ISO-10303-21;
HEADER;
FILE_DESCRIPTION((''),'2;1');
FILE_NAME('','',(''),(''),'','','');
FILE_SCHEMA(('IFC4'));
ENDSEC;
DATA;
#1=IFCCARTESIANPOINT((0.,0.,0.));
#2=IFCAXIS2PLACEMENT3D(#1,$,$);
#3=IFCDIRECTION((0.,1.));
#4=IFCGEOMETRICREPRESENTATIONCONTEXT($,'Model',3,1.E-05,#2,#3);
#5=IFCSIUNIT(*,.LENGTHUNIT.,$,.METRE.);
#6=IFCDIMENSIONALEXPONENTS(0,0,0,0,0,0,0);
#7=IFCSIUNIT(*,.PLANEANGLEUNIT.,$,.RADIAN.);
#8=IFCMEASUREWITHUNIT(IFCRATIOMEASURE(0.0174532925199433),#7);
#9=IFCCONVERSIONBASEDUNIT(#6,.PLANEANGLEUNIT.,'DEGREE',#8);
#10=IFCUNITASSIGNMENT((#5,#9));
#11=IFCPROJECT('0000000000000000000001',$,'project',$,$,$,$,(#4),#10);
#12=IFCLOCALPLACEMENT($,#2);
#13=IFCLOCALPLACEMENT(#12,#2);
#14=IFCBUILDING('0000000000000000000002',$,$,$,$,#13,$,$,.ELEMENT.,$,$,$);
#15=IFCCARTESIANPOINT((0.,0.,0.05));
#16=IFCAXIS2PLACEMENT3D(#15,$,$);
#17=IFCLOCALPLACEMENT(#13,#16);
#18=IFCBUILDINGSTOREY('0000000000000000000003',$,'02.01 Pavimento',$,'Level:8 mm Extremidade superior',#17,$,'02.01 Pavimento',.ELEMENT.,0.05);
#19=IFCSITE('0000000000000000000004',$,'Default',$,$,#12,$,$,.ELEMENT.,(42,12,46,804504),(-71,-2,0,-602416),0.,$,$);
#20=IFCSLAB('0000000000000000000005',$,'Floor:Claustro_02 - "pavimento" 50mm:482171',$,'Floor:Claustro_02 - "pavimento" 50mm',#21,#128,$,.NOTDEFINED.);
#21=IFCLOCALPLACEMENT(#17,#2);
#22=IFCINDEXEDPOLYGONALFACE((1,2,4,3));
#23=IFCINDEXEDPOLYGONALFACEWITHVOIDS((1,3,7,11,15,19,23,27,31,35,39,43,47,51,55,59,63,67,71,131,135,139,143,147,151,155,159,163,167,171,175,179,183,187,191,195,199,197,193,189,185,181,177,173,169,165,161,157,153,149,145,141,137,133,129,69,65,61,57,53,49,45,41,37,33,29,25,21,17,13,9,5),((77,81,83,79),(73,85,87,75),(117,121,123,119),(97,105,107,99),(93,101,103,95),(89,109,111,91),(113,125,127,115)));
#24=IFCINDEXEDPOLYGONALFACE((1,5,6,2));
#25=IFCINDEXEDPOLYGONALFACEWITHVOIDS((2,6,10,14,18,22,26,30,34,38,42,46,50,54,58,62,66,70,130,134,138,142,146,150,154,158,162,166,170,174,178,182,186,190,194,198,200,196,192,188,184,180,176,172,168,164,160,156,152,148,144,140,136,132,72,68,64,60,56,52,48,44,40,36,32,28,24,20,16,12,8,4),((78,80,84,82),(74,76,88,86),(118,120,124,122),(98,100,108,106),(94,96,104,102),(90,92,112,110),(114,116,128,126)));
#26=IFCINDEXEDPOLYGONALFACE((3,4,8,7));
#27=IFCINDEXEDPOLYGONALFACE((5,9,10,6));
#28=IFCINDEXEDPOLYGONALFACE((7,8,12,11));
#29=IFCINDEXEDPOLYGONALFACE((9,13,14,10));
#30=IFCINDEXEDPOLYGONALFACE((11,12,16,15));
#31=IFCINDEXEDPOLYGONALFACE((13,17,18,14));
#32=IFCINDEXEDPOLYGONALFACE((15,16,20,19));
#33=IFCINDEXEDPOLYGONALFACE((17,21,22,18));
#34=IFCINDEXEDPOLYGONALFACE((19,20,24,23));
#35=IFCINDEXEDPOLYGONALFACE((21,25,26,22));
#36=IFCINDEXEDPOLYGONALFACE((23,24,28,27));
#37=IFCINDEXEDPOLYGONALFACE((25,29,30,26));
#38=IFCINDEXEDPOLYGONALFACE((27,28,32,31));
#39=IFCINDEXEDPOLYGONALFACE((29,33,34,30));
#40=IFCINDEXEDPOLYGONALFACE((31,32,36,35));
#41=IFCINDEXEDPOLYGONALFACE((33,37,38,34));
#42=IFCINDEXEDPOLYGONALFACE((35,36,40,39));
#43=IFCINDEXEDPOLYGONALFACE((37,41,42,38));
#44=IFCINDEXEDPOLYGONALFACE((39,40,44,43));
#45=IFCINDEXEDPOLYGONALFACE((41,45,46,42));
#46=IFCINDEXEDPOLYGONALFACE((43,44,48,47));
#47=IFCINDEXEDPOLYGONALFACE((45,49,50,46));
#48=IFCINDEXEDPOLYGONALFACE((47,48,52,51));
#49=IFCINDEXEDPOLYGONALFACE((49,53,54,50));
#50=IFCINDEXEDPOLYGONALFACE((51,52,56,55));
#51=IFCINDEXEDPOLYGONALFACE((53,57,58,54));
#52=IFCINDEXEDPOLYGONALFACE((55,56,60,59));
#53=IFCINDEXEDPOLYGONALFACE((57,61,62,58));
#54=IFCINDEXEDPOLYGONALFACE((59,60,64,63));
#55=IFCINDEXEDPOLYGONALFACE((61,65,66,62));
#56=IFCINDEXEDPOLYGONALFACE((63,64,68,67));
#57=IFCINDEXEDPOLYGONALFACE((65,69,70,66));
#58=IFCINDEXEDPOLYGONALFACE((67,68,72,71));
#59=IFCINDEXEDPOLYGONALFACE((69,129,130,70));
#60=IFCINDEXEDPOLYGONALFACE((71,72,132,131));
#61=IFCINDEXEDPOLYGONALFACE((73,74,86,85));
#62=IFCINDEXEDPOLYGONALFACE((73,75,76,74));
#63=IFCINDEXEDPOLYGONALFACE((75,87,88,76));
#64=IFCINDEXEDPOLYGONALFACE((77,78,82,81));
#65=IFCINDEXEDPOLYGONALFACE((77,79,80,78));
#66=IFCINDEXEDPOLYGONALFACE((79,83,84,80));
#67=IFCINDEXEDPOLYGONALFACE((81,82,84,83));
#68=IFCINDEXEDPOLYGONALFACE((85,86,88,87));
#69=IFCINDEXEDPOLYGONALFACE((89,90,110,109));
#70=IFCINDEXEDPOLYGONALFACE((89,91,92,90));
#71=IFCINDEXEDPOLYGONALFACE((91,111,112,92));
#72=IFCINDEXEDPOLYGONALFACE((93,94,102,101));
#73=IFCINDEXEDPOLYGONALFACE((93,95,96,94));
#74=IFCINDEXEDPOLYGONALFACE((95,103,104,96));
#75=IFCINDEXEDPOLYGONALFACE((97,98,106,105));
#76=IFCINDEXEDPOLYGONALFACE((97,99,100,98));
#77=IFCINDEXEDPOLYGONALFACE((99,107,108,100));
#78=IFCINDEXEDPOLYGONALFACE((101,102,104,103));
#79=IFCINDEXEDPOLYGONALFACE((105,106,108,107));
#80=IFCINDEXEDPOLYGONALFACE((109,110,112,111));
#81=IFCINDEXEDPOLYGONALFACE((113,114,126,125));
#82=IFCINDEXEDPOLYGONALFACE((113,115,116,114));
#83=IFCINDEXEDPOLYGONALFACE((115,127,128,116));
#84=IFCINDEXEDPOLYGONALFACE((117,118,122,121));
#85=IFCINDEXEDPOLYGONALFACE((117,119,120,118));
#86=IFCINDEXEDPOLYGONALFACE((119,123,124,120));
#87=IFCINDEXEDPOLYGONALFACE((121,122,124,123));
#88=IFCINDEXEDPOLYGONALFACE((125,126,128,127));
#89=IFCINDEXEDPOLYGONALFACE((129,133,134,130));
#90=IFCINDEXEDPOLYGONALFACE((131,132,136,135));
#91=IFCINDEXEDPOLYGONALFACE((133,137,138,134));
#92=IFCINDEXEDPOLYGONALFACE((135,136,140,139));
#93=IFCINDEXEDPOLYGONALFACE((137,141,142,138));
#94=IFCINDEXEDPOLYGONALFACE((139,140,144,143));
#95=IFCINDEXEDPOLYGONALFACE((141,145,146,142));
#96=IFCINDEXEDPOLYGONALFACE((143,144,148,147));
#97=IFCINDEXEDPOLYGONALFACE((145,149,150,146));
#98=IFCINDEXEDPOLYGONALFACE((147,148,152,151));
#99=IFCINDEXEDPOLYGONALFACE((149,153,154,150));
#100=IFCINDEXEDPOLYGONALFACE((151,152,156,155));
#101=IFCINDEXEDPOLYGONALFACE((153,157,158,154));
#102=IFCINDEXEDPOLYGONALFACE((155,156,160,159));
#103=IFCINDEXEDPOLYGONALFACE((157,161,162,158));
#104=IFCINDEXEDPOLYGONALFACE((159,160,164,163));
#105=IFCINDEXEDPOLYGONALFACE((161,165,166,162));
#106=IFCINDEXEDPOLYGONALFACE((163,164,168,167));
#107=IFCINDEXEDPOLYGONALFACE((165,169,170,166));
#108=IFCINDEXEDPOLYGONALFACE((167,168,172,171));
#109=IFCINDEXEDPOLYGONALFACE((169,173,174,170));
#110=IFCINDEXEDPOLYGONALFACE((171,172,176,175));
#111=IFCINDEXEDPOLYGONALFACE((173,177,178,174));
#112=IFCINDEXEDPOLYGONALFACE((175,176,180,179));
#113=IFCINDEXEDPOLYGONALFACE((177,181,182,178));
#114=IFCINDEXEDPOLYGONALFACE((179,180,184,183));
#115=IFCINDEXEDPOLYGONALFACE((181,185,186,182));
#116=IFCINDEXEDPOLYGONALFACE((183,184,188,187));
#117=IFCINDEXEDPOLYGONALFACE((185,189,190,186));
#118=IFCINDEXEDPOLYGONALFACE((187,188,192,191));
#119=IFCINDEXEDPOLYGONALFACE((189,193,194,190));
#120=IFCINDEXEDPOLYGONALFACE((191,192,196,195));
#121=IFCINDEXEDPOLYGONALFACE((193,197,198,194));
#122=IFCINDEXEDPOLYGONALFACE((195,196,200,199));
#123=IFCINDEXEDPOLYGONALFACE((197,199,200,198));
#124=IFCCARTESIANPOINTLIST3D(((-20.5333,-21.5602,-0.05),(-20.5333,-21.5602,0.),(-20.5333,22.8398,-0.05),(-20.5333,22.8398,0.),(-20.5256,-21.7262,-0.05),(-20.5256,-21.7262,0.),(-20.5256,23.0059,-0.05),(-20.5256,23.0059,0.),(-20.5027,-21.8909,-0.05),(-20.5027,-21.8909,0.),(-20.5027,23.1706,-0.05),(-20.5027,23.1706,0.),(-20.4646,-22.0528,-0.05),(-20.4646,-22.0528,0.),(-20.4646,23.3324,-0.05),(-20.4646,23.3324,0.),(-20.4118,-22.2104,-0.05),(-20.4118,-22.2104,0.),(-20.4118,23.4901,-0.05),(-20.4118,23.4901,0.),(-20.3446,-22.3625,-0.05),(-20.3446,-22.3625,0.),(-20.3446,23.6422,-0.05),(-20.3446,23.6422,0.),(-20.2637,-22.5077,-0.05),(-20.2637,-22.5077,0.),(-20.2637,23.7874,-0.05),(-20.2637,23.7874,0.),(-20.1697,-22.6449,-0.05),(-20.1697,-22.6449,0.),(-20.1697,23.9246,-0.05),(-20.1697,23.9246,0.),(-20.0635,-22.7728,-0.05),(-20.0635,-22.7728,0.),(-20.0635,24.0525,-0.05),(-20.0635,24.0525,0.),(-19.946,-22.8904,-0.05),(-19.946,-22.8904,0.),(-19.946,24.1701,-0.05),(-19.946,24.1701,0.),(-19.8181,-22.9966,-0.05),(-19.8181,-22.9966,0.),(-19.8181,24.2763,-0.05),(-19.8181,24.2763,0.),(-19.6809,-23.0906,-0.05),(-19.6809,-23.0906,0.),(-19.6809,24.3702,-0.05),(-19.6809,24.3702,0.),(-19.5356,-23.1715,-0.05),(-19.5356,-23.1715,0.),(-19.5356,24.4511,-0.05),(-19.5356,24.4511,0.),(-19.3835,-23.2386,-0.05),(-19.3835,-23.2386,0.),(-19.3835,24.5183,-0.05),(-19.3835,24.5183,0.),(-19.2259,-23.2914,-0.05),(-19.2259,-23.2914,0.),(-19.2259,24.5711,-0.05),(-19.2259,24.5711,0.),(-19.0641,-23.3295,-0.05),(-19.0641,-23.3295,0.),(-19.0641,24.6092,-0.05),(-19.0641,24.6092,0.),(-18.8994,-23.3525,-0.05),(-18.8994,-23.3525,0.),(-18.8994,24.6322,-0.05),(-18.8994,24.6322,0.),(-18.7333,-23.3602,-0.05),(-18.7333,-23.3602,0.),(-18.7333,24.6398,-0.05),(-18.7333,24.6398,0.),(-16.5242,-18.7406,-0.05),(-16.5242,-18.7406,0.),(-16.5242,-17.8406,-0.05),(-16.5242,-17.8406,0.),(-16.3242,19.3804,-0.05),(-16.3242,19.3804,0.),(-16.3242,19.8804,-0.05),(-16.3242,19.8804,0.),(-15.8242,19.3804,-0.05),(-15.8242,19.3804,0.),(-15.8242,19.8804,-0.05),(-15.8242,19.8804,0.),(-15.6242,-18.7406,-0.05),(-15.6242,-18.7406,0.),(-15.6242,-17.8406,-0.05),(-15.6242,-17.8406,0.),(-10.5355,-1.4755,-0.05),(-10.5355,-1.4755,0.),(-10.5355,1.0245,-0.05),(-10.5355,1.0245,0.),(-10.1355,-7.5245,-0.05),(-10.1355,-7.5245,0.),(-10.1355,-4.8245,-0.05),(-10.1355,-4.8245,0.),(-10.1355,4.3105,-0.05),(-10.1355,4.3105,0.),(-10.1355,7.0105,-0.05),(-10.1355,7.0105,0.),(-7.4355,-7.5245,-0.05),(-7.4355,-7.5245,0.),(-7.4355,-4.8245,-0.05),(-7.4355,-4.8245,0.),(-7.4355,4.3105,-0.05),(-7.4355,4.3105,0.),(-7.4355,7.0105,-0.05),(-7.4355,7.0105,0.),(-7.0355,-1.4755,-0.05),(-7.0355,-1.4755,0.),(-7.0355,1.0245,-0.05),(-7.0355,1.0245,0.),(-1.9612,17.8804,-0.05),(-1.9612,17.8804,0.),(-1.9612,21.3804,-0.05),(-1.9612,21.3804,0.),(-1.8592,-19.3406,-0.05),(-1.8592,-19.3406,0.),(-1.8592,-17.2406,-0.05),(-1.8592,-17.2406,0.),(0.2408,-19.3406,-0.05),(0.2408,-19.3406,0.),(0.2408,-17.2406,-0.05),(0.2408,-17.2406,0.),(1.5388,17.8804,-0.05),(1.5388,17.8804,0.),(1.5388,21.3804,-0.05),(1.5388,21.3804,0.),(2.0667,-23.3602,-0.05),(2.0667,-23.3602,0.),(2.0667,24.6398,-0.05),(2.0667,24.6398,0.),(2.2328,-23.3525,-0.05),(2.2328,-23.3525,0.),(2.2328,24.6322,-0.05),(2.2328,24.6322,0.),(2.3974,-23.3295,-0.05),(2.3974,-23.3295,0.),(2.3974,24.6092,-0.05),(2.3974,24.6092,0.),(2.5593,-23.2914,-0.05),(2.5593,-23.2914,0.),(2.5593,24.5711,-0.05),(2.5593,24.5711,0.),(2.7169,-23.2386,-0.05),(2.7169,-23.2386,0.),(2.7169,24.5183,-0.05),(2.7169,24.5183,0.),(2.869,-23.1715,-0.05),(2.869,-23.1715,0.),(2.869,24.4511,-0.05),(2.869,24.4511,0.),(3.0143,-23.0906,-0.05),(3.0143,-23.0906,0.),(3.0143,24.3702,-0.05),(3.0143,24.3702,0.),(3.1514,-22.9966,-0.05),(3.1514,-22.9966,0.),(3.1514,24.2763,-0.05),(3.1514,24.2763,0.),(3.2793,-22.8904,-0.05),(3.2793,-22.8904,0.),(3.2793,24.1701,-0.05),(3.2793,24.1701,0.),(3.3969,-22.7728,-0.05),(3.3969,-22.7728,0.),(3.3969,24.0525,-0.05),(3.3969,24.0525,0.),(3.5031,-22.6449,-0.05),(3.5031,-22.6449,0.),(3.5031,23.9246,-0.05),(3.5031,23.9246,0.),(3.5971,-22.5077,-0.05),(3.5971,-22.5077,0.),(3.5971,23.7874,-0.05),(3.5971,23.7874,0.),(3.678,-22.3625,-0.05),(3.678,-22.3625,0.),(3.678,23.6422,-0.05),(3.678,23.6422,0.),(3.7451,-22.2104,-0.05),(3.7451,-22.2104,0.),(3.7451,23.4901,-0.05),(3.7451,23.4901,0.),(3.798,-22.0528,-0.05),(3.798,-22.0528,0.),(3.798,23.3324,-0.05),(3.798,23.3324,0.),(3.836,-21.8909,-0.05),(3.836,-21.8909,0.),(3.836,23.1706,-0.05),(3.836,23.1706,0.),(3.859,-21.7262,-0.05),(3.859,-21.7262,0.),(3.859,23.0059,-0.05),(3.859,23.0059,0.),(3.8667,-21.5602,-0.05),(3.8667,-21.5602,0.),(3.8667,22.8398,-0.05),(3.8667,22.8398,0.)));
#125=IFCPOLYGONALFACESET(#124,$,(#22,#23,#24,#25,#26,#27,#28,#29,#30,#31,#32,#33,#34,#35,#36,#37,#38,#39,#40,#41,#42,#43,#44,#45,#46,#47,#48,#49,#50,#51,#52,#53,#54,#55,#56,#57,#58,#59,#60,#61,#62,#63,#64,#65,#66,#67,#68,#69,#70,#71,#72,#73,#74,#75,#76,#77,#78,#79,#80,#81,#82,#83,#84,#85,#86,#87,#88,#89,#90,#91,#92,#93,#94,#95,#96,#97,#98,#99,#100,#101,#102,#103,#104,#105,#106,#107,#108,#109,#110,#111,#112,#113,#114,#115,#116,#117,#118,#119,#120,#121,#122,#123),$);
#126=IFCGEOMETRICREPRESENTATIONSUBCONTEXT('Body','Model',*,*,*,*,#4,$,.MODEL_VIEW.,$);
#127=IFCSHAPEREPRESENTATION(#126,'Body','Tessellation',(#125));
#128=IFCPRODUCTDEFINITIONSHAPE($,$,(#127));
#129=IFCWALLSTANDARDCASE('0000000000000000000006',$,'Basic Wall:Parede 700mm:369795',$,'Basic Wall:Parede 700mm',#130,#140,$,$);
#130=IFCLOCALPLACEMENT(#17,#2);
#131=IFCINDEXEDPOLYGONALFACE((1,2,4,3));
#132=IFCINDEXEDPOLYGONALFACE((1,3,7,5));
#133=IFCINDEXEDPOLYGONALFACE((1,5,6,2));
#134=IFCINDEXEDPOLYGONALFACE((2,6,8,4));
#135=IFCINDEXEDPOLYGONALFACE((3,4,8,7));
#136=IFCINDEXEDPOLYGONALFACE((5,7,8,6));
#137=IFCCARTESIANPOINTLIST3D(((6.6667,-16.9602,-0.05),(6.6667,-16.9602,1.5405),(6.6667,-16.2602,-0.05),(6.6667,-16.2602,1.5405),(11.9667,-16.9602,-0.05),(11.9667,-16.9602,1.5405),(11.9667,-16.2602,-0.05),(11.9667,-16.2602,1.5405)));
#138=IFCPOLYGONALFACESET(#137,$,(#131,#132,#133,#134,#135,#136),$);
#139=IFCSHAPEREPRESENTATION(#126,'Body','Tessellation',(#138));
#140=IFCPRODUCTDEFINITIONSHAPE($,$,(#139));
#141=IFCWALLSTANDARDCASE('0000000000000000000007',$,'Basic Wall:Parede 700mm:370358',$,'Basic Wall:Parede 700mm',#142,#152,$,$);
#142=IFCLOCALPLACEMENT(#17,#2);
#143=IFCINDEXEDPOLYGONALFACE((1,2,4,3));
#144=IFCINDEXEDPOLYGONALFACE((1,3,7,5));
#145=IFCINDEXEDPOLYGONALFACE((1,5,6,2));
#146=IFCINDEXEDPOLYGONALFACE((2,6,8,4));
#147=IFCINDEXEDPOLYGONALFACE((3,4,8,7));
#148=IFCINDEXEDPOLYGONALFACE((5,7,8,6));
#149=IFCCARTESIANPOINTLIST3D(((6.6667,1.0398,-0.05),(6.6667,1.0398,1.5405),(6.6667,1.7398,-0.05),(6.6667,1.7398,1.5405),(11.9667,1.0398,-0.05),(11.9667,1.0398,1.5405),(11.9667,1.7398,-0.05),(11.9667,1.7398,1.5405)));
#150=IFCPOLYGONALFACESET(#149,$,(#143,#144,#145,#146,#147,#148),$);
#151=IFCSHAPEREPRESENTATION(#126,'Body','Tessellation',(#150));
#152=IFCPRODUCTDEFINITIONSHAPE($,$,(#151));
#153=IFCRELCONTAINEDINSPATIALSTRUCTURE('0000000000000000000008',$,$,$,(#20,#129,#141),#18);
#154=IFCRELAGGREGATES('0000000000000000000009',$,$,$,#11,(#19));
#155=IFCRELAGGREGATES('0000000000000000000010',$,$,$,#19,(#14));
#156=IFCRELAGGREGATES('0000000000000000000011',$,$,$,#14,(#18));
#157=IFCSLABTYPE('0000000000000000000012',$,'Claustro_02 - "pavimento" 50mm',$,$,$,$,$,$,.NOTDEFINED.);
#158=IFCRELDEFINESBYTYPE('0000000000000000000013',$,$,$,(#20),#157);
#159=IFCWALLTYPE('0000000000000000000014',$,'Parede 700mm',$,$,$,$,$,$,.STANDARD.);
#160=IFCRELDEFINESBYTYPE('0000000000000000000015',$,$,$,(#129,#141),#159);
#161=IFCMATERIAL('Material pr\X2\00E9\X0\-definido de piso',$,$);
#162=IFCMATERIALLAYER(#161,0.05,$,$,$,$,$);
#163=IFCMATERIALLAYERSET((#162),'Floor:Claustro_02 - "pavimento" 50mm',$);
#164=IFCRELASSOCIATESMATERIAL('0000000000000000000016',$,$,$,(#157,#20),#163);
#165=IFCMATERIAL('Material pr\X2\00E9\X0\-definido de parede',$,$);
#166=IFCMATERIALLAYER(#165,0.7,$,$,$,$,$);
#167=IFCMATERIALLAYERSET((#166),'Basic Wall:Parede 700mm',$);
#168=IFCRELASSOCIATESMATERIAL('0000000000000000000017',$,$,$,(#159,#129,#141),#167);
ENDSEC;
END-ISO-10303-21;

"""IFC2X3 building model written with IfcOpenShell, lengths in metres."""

from ifc_helpers import new_model, entity, si_unit, converted_unit, direction, frame, frame_2d, origin, origin_2d_with_axis, place, context, subcontext, project, spatial, polyline, circle_curve, parameter, trimmed, segment, composite_curve, rectangle, outline, extrude, clip, halfspace, material, layer, layer_set, layer_usage, type_object, element, save


model = new_model("IFC2X3")

# Units and contexts
model_context = context("Model", 3, precision=1e-05, world=origin(), true_north=direction((0.0, 1.0)))
body_context = subcontext(model_context, "Body", "Model", "MODEL_VIEW")
ifc_project = project(units=[si_unit("LENGTHUNIT", "METRE"), converted_unit("PLANEANGLEUNIT", "DEGREE", entity("IfcRatioMeasure", 0.0174532925199433), si_unit("PLANEANGLEUNIT", "RADIAN"), dimensions=[0, 0, 0, 0, 0, 0, 0])], contexts=[model_context])

# Site, building, storey
site_placement = place(None, origin())
site = spatial("IfcSite", under=ifc_project, at=site_placement, Name="Default", CompositionType="ELEMENT", RefLatitude=(42, 12, 46, 804504), RefLongitude=(-71, -2, 0, -602416), RefElevation=0.0)
building_placement = place(site_placement, origin())
building = spatial("IfcBuilding", under=site, at=building_placement, CompositionType="ELEMENT")
storey_placement = place(building_placement, frame((0.0, 0.0, 0.05)))
storey = spatial("IfcBuildingStorey", under=building, at=storey_placement, Name="02.01 Pavimento", ObjectType="Level:8 mm Extremidade superior", LongName="02.01 Pavimento", CompositionType="ELEMENT", Elevation=0.05)

# Shared definitions
ifc_material_1 = material(Name="Material pré-definido de piso")

# Slab, openings
ifc_layer_1 = layer(ifc_material_1, 0.05)
ifc_layer_set_1 = layer_set([ifc_layer_1], Name="Floor:Claustro_02 - \"pavimento\" 50mm")
ifc_layer_usage_1 = layer_usage(ifc_layer_set_1, "AXIS3", "POSITIVE", 0.0)
slab_type_1 = type_object("IfcSlabType", Name="Claustro_02 - \"pavimento\" 50mm", PredefinedType="NOTDEFINED", material=ifc_layer_set_1)
slab_1_placement = place(storey_placement, origin())
slab_1 = element("IfcSlab", 1, at=slab_1_placement, inside=storey, type_object=slab_type_1, material=ifc_layer_usage_1, Name="Floor:Claustro_02 - \"pavimento\" 50mm:482171", ObjectType="Floor:Claustro_02 - \"pavimento\" 50mm", PredefinedType="NOTDEFINED", context=body_context, shape_type="SweptSolid", body=[
    extrude(outline(composite_curve([segment(trimmed(circle_curve(frame_2d((-10.4, 22.2), x_axis=(-1.0, 0.0)), 1.8), [parameter(270.0)], [parameter(0.0)], True, "PARAMETER"), True, "CONTINUOUS"), segment(polyline([(-12.2, 22.2), (-12.2, 3.95)]), True, "CONTINUOUS"), segment(polyline([(-12.2, 3.95), (-12.2, -22.2)]), True, "CONTINUOUS"), segment(trimmed(circle_curve(frame_2d((-10.4, -22.2), x_axis=(-1.0, 0.0)), 1.8), [parameter(0.0)], [parameter(90.0)], True, "PARAMETER"), True, "CONTINUOUS"), segment(polyline([(-10.4, -24.0), (10.4, -24.0)]), True, "CONTINUOUS"), segment(trimmed(circle_curve(frame_2d((10.4, -22.2), x_axis=(-1.0, 0.0)), 1.8), [parameter(90.0)], [parameter(180.0)], True, "PARAMETER"), True, "CONTINUOUS"), segment(polyline([(12.2, -22.2), (12.2, 3.95)]), True, "CONTINUOUS"), segment(polyline([(12.2, 3.95), (12.2, 22.2)]), True, "CONTINUOUS"), segment(trimmed(circle_curve(frame_2d((10.4, 22.2), x_axis=(-1.0, 0.0)), 1.8), [parameter(180.0)], [parameter(270.0)], True, "PARAMETER"), True, "CONTINUOUS"), segment(polyline([(10.4, 24.0), (-10.4, 24.0)]), True, "CONTINUOUS")], self_intersect=False)), frame((-8.3333, 0.6398, 0.0), z_axis=(0.0, 0.0, -1.0), x_axis=(-1.0, 0.0, 0.0)), (0.0, 0.0, 1.0), 0.05),
])
opening_1_placement = place(slab_1_placement, frame((-0.2112, 19.6304, 0.0)))
element("IfcOpeningElement", 2, at=opening_1_placement, cuts=slab_1, ObjectType="Opening", context=body_context, shape_type="SweptSolid", body=[
    extrude(rectangle(XDim=3.5, YDim=3.5, at=origin_2d_with_axis()), frame((0.0, 0.0, 0.0), z_axis=(0.0, 0.0, -1.0), x_axis=(0.0, -1.0, 0.0)), (0.0, 0.0, 1.0), 0.05),
])
opening_2_placement = place(slab_1_placement, frame((-16.0742, 19.6304, 0.0)))
element("IfcOpeningElement", 3, at=opening_2_placement, cuts=slab_1, ObjectType="Opening", context=body_context, shape_type="SweptSolid", body=[
    extrude(rectangle(XDim=0.5, YDim=0.5, at=origin_2d_with_axis()), frame((0.0, 0.0, 0.0), z_axis=(0.0, 0.0, -1.0), x_axis=(0.0, -1.0, 0.0)), (0.0, 0.0, 1.0), 0.05),
])
opening_3_placement = place(slab_1_placement, frame((-8.7855, 5.6605, 0.0)))
element("IfcOpeningElement", 4, at=opening_3_placement, cuts=slab_1, ObjectType="Opening", context=body_context, shape_type="SweptSolid", body=[
    extrude(rectangle(XDim=2.7, YDim=2.7, at=origin_2d_with_axis()), frame((0.0, 0.0, 0.0), z_axis=(0.0, 0.0, -1.0), x_axis=(0.0, -1.0, 0.0)), (0.0, 0.0, 1.0), 0.05),
])
opening_4_placement = place(slab_1_placement, frame((-8.7855, -0.2255, 0.0)))
element("IfcOpeningElement", 5, at=opening_4_placement, cuts=slab_1, ObjectType="Opening", context=body_context, shape_type="SweptSolid", body=[
    extrude(rectangle(XDim=2.5, YDim=3.5, at=origin_2d_with_axis()), frame((0.0, 0.0, 0.0), z_axis=(0.0, 0.0, -1.0), x_axis=(0.0, -1.0, 0.0)), (0.0, 0.0, 1.0), 0.05),
])
opening_5_placement = place(slab_1_placement, frame((-8.7855, -6.1745, 0.0)))
element("IfcOpeningElement", 6, at=opening_5_placement, cuts=slab_1, ObjectType="Opening", context=body_context, shape_type="SweptSolid", body=[
    extrude(rectangle(XDim=2.7, YDim=2.7, at=origin_2d_with_axis()), frame((0.0, 0.0, 0.0), z_axis=(0.0, 0.0, -1.0), x_axis=(0.0, -1.0, 0.0)), (0.0, 0.0, 1.0), 0.05),
])
opening_6_placement = place(slab_1_placement, frame((-16.0742, -18.2906, 0.0)))
element("IfcOpeningElement", 7, at=opening_6_placement, cuts=slab_1, ObjectType="Opening", context=body_context, shape_type="SweptSolid", body=[
    extrude(rectangle(XDim=0.9, YDim=0.9, at=origin_2d_with_axis()), frame((0.0, 0.0, 0.0), z_axis=(0.0, 0.0, -1.0), x_axis=(0.0, -1.0, 0.0)), (0.0, 0.0, 1.0), 0.05),
])
opening_7_placement = place(slab_1_placement, frame((-0.8092, -18.2906, 0.0)))
element("IfcOpeningElement", 8, at=opening_7_placement, cuts=slab_1, ObjectType="Opening", context=body_context, shape_type="SweptSolid", body=[
    extrude(rectangle(XDim=2.1, YDim=2.1, at=origin_2d_with_axis()), frame((0.0, 0.0, 0.0), z_axis=(0.0, 0.0, -1.0), x_axis=(0.0, -1.0, 0.0)), (0.0, 0.0, 1.0), 0.05),
])

# Walls
ifc_material_2 = material(Name="Material pré-definido de parede")
ifc_layer_2 = layer(ifc_material_2, 0.7)
ifc_layer_set_2 = layer_set([ifc_layer_2], Name="Basic Wall:Parede 700mm")
ifc_layer_usage_2 = layer_usage(ifc_layer_set_2, "AXIS2", "NEGATIVE", 0.35)
wall_type_1 = type_object("IfcWallType", Name="Parede 700mm", PredefinedType="STANDARD", material=ifc_layer_set_2)
wall_1_placement = place(storey_placement, frame((6.6667, -16.6102, -0.05)))
element("IfcWallStandardCase", 9, at=wall_1_placement, inside=storey, type_object=wall_type_1, material=ifc_layer_usage_2, Name="Basic Wall:Parede 700mm:369795", ObjectType="Basic Wall:Parede 700mm", context=body_context, shape_type="Clipping", body=[
    clip(extrude(rectangle(XDim=0.7, YDim=5.3, at=frame_2d((2.65, 0.0), x_axis=(0.0, 1.0))), origin(), (0.0, 0.0, 1.0), 1.5905), halfspace(frame((0.0, 0.0, -0.05)), True)),
])
ifc_layer_usage_3 = layer_usage(ifc_layer_set_2, "AXIS2", "POSITIVE", -0.35)
wall_2_placement = place(storey_placement, frame((6.6667, 1.3898, -0.05)))
element("IfcWallStandardCase", 10, at=wall_2_placement, inside=storey, type_object=wall_type_1, material=ifc_layer_usage_3, Name="Basic Wall:Parede 700mm:370358", ObjectType="Basic Wall:Parede 700mm", context=body_context, shape_type="Clipping", body=[
    clip(extrude(rectangle(XDim=0.7, YDim=5.3, at=frame_2d((2.65, 0.0), x_axis=(0.0, 1.0))), origin(), (0.0, 0.0, 1.0), 1.5905), halfspace(frame((0.0, 0.0, -0.05)), True)),
])

save(model, "model.ifc")
